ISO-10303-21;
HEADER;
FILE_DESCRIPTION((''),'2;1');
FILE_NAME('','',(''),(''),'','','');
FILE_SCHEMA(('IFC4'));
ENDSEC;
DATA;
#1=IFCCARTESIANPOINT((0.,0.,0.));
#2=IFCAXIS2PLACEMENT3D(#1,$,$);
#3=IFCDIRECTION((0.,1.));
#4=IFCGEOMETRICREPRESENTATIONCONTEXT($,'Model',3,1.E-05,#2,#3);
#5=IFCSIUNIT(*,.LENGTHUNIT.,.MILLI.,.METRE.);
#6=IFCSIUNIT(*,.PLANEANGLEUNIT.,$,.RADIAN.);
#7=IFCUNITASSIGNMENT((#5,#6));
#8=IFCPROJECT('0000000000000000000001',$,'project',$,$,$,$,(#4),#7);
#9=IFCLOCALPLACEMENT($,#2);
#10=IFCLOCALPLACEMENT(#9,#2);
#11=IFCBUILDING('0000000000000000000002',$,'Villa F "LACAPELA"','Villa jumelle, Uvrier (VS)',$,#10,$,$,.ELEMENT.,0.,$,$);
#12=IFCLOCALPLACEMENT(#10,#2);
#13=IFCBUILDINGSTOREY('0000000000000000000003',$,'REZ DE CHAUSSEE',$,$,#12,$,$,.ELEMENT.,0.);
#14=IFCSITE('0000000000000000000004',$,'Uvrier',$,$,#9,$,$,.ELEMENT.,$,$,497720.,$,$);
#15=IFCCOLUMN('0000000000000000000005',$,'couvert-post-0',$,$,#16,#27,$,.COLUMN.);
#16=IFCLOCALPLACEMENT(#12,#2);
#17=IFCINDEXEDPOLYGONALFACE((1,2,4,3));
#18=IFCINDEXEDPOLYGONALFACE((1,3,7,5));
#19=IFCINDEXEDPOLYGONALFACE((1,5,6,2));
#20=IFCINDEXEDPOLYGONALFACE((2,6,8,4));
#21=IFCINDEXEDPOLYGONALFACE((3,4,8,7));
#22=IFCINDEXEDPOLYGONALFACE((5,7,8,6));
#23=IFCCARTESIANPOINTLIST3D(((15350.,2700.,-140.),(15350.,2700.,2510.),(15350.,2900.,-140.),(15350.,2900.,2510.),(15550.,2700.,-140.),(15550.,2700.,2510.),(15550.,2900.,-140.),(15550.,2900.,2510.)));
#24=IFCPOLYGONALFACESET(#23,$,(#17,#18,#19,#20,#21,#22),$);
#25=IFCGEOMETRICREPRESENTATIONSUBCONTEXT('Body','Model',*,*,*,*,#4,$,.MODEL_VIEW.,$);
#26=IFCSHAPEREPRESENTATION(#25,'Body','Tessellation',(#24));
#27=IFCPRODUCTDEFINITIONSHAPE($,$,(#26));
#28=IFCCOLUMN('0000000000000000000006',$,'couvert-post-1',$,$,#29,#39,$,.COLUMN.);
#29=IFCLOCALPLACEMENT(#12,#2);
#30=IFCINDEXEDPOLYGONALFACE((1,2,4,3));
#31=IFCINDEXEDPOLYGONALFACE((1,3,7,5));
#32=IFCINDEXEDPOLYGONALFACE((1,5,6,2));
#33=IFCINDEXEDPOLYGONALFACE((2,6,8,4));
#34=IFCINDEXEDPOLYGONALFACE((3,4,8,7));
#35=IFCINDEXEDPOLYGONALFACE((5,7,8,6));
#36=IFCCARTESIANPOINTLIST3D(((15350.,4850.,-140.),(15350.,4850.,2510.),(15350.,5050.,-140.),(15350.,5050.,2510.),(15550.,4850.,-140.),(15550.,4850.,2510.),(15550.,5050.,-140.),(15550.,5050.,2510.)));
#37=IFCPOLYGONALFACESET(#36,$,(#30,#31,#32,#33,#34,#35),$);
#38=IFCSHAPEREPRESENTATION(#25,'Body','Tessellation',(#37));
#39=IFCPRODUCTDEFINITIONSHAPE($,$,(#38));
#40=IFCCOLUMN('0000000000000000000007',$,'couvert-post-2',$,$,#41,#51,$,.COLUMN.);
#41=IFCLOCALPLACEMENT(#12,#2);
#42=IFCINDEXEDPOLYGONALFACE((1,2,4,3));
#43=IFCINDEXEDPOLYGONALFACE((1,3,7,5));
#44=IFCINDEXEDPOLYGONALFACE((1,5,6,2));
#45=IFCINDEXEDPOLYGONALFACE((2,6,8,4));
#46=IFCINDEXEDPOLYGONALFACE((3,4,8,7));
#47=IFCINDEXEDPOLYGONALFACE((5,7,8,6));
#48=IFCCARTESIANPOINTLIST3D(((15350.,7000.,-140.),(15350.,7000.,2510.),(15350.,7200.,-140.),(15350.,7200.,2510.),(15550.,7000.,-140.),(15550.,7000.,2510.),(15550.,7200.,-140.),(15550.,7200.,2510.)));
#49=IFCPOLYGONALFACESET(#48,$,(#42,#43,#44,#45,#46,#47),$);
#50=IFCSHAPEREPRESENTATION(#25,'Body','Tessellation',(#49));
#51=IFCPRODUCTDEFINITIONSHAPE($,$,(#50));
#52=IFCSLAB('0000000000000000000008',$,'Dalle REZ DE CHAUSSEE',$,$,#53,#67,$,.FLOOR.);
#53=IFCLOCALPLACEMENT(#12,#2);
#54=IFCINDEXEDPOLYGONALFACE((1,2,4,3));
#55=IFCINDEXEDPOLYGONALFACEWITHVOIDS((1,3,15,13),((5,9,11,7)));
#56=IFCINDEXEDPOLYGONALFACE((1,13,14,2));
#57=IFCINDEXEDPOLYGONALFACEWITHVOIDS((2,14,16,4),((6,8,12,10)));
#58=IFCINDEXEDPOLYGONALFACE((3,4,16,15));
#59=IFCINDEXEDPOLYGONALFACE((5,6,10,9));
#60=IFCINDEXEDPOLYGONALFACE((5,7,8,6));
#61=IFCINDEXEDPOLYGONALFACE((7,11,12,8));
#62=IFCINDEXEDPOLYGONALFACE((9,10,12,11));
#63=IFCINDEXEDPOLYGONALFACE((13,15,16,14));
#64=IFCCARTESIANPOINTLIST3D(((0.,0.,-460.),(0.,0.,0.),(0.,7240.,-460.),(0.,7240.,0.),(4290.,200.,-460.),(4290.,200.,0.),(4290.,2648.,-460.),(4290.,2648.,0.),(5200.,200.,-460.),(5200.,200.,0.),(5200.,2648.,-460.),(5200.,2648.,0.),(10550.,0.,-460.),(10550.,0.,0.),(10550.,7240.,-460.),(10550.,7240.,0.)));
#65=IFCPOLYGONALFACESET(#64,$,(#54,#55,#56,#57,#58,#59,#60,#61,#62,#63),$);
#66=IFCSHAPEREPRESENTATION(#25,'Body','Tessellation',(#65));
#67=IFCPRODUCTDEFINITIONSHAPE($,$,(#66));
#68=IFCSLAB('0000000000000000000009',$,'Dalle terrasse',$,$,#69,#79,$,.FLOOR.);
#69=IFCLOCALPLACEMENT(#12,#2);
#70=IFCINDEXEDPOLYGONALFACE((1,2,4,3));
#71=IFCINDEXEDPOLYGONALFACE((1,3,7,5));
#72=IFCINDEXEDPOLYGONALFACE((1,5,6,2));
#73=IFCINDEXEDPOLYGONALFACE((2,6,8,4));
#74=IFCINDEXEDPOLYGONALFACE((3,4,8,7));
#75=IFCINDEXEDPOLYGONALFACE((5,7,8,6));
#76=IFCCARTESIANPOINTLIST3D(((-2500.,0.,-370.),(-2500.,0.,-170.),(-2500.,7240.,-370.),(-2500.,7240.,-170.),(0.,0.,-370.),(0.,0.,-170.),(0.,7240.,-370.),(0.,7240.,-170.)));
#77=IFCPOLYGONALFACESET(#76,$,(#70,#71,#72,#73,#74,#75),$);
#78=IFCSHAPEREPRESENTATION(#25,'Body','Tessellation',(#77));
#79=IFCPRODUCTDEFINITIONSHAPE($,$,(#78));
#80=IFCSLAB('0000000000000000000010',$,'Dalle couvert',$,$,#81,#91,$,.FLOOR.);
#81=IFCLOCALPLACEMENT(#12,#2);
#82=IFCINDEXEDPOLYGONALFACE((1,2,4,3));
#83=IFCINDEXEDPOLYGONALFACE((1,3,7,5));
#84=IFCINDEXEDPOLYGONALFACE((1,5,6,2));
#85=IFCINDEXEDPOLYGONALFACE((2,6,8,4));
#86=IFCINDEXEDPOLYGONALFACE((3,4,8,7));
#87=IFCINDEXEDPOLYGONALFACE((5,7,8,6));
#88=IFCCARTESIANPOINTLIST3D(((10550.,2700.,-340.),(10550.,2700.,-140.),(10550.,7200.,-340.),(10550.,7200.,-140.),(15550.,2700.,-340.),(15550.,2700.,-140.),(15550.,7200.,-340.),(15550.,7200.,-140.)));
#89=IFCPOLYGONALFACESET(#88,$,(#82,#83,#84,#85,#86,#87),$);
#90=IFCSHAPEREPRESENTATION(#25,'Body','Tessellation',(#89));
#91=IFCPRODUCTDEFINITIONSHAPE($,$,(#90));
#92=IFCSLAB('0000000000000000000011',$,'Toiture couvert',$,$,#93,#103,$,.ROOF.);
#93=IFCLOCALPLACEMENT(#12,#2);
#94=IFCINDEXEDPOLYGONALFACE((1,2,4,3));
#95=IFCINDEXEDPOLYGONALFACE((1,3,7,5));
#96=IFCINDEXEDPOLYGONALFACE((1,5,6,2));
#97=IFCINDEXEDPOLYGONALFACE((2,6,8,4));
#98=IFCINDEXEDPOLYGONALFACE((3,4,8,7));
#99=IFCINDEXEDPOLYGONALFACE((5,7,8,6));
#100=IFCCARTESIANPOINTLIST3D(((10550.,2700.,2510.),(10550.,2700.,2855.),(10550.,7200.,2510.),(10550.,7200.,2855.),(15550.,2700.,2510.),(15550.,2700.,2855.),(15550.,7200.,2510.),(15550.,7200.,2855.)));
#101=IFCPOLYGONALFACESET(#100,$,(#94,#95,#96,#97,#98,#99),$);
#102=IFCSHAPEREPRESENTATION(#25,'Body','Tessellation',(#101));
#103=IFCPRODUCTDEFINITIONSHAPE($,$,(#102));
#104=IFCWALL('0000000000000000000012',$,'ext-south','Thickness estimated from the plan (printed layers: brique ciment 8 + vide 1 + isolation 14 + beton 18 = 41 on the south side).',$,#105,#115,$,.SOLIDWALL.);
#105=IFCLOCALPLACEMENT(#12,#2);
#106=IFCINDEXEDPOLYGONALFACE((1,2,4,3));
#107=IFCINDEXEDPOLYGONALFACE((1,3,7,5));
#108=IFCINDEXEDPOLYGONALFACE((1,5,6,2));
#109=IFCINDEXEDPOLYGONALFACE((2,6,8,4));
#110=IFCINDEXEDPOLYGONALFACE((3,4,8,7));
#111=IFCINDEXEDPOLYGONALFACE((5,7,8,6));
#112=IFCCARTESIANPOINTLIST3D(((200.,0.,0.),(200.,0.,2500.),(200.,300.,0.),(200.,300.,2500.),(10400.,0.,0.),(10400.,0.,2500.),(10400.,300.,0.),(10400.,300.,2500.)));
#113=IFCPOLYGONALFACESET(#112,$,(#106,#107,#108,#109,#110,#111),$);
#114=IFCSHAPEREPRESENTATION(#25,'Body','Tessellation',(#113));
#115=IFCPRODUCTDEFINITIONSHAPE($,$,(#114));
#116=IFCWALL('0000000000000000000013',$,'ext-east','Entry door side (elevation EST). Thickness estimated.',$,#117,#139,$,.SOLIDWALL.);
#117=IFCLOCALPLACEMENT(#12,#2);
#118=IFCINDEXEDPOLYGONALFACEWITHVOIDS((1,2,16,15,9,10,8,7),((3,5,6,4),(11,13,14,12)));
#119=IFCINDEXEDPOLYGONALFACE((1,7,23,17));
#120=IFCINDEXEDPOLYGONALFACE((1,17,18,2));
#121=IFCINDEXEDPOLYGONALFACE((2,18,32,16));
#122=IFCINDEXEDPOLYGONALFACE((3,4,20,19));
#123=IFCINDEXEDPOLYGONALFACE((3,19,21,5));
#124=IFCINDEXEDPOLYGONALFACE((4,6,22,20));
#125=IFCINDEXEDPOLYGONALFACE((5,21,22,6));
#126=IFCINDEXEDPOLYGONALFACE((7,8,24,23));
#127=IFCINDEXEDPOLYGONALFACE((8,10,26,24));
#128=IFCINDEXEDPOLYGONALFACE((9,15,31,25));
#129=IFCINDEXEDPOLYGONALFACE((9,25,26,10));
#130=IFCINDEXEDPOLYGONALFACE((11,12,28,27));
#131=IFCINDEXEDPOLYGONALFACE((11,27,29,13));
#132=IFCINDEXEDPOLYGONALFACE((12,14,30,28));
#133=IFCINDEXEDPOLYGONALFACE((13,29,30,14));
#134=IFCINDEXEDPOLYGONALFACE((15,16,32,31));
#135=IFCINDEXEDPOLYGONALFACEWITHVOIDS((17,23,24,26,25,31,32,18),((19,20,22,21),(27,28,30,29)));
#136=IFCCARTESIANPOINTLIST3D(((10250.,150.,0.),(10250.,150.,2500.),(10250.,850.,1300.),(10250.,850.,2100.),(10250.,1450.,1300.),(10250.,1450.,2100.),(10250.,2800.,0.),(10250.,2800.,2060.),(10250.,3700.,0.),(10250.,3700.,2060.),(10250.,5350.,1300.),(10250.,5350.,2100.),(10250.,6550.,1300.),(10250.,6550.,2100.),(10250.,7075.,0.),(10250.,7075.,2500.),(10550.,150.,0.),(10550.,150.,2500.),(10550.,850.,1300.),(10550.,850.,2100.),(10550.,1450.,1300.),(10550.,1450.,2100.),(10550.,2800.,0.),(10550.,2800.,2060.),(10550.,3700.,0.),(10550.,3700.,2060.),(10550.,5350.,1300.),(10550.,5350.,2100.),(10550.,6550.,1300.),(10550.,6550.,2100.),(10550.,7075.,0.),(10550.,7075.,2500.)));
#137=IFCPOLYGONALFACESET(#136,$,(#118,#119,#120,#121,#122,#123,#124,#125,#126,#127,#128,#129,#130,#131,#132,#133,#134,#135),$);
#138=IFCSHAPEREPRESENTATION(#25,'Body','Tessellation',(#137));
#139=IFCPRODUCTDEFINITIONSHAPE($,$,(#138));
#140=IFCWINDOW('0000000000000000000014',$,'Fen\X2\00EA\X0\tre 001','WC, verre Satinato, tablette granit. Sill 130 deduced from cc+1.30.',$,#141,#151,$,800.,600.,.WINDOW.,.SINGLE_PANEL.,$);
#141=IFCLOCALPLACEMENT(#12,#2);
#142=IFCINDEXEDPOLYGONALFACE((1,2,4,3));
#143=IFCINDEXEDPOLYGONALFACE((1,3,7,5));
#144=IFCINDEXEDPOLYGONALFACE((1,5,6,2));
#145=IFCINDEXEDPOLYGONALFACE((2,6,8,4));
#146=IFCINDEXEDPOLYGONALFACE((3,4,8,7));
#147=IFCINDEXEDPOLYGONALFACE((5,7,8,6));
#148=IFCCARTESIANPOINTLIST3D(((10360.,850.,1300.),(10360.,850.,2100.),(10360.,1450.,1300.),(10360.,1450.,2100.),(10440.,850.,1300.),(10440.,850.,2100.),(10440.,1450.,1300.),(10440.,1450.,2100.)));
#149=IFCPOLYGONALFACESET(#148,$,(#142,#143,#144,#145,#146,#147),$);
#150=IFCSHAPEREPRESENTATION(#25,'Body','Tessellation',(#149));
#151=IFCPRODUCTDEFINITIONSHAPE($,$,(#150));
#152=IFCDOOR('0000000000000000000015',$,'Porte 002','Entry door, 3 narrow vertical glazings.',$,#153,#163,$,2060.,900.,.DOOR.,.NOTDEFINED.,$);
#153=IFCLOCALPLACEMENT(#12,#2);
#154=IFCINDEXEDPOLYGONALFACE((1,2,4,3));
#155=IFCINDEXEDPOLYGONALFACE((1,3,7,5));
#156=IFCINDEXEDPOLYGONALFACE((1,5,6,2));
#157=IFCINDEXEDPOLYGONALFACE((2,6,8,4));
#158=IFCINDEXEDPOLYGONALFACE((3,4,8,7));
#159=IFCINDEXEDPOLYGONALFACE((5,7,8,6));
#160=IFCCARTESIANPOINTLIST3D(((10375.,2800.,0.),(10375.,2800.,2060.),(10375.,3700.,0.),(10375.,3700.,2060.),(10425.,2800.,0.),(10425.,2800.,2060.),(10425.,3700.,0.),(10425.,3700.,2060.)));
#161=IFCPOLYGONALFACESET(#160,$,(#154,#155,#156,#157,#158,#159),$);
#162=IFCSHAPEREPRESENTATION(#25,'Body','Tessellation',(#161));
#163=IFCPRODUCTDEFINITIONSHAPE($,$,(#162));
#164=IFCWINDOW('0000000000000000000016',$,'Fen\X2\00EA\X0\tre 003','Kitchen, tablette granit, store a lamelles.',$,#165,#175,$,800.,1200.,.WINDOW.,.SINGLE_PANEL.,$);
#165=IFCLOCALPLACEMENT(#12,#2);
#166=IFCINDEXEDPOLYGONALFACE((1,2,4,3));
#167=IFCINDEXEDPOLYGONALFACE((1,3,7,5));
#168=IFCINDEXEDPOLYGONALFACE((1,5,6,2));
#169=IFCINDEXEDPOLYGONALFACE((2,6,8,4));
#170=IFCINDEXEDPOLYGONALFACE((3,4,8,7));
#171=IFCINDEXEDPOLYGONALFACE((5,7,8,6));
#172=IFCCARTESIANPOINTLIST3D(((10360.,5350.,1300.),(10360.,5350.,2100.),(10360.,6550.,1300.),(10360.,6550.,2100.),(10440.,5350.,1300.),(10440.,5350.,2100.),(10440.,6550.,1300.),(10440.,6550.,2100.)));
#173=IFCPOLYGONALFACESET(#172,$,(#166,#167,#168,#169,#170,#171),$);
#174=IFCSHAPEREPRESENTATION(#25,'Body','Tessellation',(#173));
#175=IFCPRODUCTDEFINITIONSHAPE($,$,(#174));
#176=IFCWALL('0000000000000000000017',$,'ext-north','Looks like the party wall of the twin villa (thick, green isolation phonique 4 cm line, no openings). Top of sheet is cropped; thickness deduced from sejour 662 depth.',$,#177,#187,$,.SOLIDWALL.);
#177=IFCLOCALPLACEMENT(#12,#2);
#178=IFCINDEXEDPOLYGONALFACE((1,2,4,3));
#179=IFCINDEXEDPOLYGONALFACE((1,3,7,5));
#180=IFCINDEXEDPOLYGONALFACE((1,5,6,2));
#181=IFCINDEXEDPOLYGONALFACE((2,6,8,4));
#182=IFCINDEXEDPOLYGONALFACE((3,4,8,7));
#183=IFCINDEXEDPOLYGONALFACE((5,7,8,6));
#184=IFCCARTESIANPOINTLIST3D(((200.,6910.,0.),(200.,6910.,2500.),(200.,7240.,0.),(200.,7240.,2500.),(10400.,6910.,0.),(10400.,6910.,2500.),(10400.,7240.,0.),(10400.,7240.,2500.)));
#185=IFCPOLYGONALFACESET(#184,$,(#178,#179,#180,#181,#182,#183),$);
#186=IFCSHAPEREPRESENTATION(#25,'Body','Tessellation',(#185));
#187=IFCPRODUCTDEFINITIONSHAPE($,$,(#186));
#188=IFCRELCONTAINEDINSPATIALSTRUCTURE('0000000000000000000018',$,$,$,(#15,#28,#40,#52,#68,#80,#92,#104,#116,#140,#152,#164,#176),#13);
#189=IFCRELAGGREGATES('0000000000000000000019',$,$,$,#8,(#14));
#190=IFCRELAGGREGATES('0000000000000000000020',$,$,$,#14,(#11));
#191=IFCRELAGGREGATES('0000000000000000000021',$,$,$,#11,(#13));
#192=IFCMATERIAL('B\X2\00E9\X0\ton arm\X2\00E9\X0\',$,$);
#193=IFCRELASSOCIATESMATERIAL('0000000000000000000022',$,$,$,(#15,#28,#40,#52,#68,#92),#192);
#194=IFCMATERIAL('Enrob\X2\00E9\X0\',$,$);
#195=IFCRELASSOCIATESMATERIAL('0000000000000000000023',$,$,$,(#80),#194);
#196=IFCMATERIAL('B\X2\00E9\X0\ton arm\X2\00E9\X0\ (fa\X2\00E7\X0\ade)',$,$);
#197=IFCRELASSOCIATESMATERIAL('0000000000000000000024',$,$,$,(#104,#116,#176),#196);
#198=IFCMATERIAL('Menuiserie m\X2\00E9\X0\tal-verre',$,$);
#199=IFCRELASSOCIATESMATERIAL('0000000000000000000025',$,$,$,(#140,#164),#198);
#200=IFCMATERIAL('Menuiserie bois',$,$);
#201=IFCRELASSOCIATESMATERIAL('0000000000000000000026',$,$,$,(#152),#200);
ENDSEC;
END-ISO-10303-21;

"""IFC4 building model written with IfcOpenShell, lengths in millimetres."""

from ifc_helpers import new_model, si_unit, direction, frame, frame_2d, origin, place, context, subcontext, project, spatial, polyline, rectangle, outline, extrude, material, element, fill, save


model = new_model("IFC4")

# Units and contexts
model_context = context("Model", 3, precision=1e-05, world=origin(), true_north=direction((0.0, 1.0)))
body_context = subcontext(model_context, "Body", "Model", "MODEL_VIEW")
ifc_project = project(units=[si_unit("LENGTHUNIT", "METRE", prefix="MILLI"), si_unit("PLANEANGLEUNIT", "RADIAN")], contexts=[model_context])

# Site, building, storey
site_placement = place(None, origin())
site = spatial("IfcSite", under=ifc_project, at=site_placement, Name="Uvrier", CompositionType="ELEMENT", RefElevation=497720.0)
building_placement = place(site_placement, origin())
building = spatial("IfcBuilding", under=site, at=building_placement, Name="Villa F \"LACAPELA\"", Description="Villa jumelle, Uvrier (VS)", CompositionType="ELEMENT", ElevationOfRefHeight=0.0)
storey_placement = place(building_placement, origin())
storey = spatial("IfcBuildingStorey", under=building, at=storey_placement, Name="REZ DE CHAUSSEE", CompositionType="ELEMENT", Elevation=0.0)

# Columns
ifc_material_1 = material(Name="Béton armé")
column_1_placement = place(storey_placement, origin())
element("IfcColumn", 1, at=column_1_placement, inside=storey, material=ifc_material_1, Name="couvert-post-0", PredefinedType="COLUMN", context=body_context, shape_type="SweptSolid", body=[
    extrude(rectangle(XDim=200.0, YDim=200.0, at=frame_2d((15450.0, 2800.0))), frame((0.0, 0.0, -140.0)), (0.0, 0.0, 1.0), 2650.0),
])
column_2_placement = place(storey_placement, origin())
element("IfcColumn", 2, at=column_2_placement, inside=storey, material=ifc_material_1, Name="couvert-post-1", PredefinedType="COLUMN", context=body_context, shape_type="SweptSolid", body=[
    extrude(rectangle(XDim=200.0, YDim=200.0, at=frame_2d((15450.0, 4950.0))), frame((0.0, 0.0, -140.0)), (0.0, 0.0, 1.0), 2650.0),
])
column_3_placement = place(storey_placement, origin())
element("IfcColumn", 3, at=column_3_placement, inside=storey, material=ifc_material_1, Name="couvert-post-2", PredefinedType="COLUMN", context=body_context, shape_type="SweptSolid", body=[
    extrude(rectangle(XDim=200.0, YDim=200.0, at=frame_2d((15450.0, 7100.0))), frame((0.0, 0.0, -140.0)), (0.0, 0.0, 1.0), 2650.0),
])

# Slabs
slab_1_placement = place(storey_placement, origin())
element("IfcSlab", 4, at=slab_1_placement, inside=storey, material=ifc_material_1, Name="Dalle REZ DE CHAUSSEE", PredefinedType="FLOOR", context=body_context, shape_type="SweptSolid", body=[
    extrude(outline(polyline([(0.0, 0.0), (10550.0, 0.0), (10550.0, 7240.0), (0.0, 7240.0), (0.0, 0.0)]), holes=[polyline([(4290.0, 200.0), (5200.0, 200.0), (5200.0, 2648.0), (4290.0, 2648.0), (4290.0, 200.0)])]), frame((0.0, 0.0, -460.0)), (0.0, 0.0, 1.0), 460.0),
])
slab_2_placement = place(storey_placement, origin())
element("IfcSlab", 5, at=slab_2_placement, inside=storey, material=ifc_material_1, Name="Dalle terrasse", PredefinedType="FLOOR", context=body_context, shape_type="SweptSolid", body=[
    extrude(outline(polyline([(-2500.0, 0.0), (0.0, 0.0), (0.0, 7240.0), (-2500.0, 7240.0), (-2500.0, 0.0)])), frame((0.0, 0.0, -370.0)), (0.0, 0.0, 1.0), 200.0),
])
ifc_material_2 = material(Name="Enrobé")
slab_3_placement = place(storey_placement, origin())
element("IfcSlab", 6, at=slab_3_placement, inside=storey, material=ifc_material_2, Name="Dalle couvert", PredefinedType="FLOOR", context=body_context, shape_type="SweptSolid", body=[
    extrude(outline(polyline([(10550.0, 2700.0), (15550.0, 2700.0), (15550.0, 7200.0), (10550.0, 7200.0), (10550.0, 2700.0)])), frame((0.0, 0.0, -340.0)), (0.0, 0.0, 1.0), 200.0),
])
slab_4_placement = place(storey_placement, origin())
element("IfcSlab", 7, at=slab_4_placement, inside=storey, material=ifc_material_1, Name="Toiture couvert", PredefinedType="ROOF", context=body_context, shape_type="SweptSolid", body=[
    extrude(outline(polyline([(10550.0, 2700.0), (15550.0, 2700.0), (15550.0, 7200.0), (10550.0, 7200.0), (10550.0, 2700.0)])), frame((0.0, 0.0, 2510.0)), (0.0, 0.0, 1.0), 345.0),
])

# Wall
ifc_material_3 = material(Name="Béton armé (façade)")
wall_1_placement = place(storey_placement, frame((200.0, 150.0, 0.0), z_axis=(0.0, 0.0, 1.0), x_axis=(1.0, 0.0, 0.0)))
element("IfcWall", 8, at=wall_1_placement, inside=storey, material=ifc_material_3, Name="ext-south", Description="Thickness estimated from the plan (printed layers: brique ciment 8 + vide 1 + isolation 14 + beton 18 = 41 on the south side).", PredefinedType="SOLIDWALL", context=body_context, shape_type="SweptSolid", body=[
    extrude(rectangle(XDim=10200.0, YDim=300.0, at=frame_2d((5100.0, 0.0))), origin(), (0.0, 0.0, 1.0), 2500.0),
])

# Wall, openings, windows, door
wall_2_placement = place(storey_placement, frame((10400.0, 150.0, 0.0), z_axis=(0.0, 0.0, 1.0), x_axis=(0.0, 1.0, 0.0)))
wall_2 = element("IfcWall", 9, at=wall_2_placement, inside=storey, material=ifc_material_3, Name="ext-east", Description="Entry door side (elevation EST). Thickness estimated.", PredefinedType="SOLIDWALL", context=body_context, shape_type="SweptSolid", body=[
    extrude(rectangle(XDim=6925.0, YDim=300.0, at=frame_2d((3462.5, 0.0))), origin(), (0.0, 0.0, 1.0), 2500.0),
])
opening_1_placement = place(wall_2_placement, frame((700.0, 0.0, 1300.0)))
opening_1 = element("IfcOpeningElement", 10, at=opening_1_placement, cuts=wall_2, PredefinedType="OPENING", context=body_context, shape_type="SweptSolid", body=[
    extrude(rectangle(XDim=600.0, YDim=500.0, at=frame_2d((300.0, 0.0))), origin(), (0.0, 0.0, 1.0), 800.0),
])
opening_2_placement = place(wall_2_placement, frame((2650.0, 0.0, 0.0)))
opening_2 = element("IfcOpeningElement", 11, at=opening_2_placement, cuts=wall_2, PredefinedType="OPENING", context=body_context, shape_type="SweptSolid", body=[
    extrude(rectangle(XDim=900.0, YDim=500.0, at=frame_2d((450.0, 0.0))), origin(), (0.0, 0.0, 1.0), 2060.0),
])
opening_3_placement = place(wall_2_placement, frame((5200.0, 0.0, 1300.0)))
opening_3 = element("IfcOpeningElement", 12, at=opening_3_placement, cuts=wall_2, PredefinedType="OPENING", context=body_context, shape_type="SweptSolid", body=[
    extrude(rectangle(XDim=1200.0, YDim=500.0, at=frame_2d((600.0, 0.0))), origin(), (0.0, 0.0, 1.0), 800.0),
])
ifc_material_4 = material(Name="Menuiserie métal-verre")
window_1_placement = place(opening_1_placement, origin())
window_1 = element("IfcWindow", 13, at=window_1_placement, inside=storey, material=ifc_material_4, Name="Fenêtre 001", Description="WC, verre Satinato, tablette granit. Sill 130 deduced from cc+1.30.", OverallHeight=800.0, OverallWidth=600.0, PartitioningType="SINGLE_PANEL", PredefinedType="WINDOW", context=body_context, shape_type="SweptSolid", body=[
    extrude(rectangle(XDim=600.0, YDim=80.0, at=frame_2d((300.0, 0.0))), origin(), (0.0, 0.0, 1.0), 800.0),
])
fill(opening_1, window_1)
ifc_material_5 = material(Name="Menuiserie bois")
door_1_placement = place(opening_2_placement, origin())
door_1 = element("IfcDoor", 14, at=door_1_placement, inside=storey, material=ifc_material_5, Name="Porte 002", Description="Entry door, 3 narrow vertical glazings.", OperationType="NOTDEFINED", OverallHeight=2060.0, OverallWidth=900.0, PredefinedType="DOOR", context=body_context, shape_type="SweptSolid", body=[
    extrude(rectangle(XDim=900.0, YDim=50.0, at=frame_2d((450.0, 0.0))), origin(), (0.0, 0.0, 1.0), 2060.0),
])
fill(opening_2, door_1)
window_2_placement = place(opening_3_placement, origin())
window_2 = element("IfcWindow", 15, at=window_2_placement, inside=storey, material=ifc_material_4, Name="Fenêtre 003", Description="Kitchen, tablette granit, store a lamelles.", OverallHeight=800.0, OverallWidth=1200.0, PartitioningType="SINGLE_PANEL", PredefinedType="WINDOW", context=body_context, shape_type="SweptSolid", body=[
    extrude(rectangle(XDim=1200.0, YDim=80.0, at=frame_2d((600.0, 0.0))), origin(), (0.0, 0.0, 1.0), 800.0),
])
fill(opening_3, window_2)

# Wall
wall_3_placement = place(storey_placement, frame((200.0, 7075.0, 0.0), z_axis=(0.0, 0.0, 1.0), x_axis=(1.0, 0.0, 0.0)))
element("IfcWall", 16, at=wall_3_placement, inside=storey, material=ifc_material_3, Name="ext-north", Description="Looks like the party wall of the twin villa (thick, green isolation phonique 4 cm line, no openings). Top of sheet is cropped; thickness deduced from sejour 662 depth.", PredefinedType="SOLIDWALL", context=body_context, shape_type="SweptSolid", body=[
    extrude(rectangle(XDim=10200.0, YDim=330.0, at=frame_2d((5100.0, 0.0))), origin(), (0.0, 0.0, 1.0), 2500.0),
])

save(model, "model.ifc")
